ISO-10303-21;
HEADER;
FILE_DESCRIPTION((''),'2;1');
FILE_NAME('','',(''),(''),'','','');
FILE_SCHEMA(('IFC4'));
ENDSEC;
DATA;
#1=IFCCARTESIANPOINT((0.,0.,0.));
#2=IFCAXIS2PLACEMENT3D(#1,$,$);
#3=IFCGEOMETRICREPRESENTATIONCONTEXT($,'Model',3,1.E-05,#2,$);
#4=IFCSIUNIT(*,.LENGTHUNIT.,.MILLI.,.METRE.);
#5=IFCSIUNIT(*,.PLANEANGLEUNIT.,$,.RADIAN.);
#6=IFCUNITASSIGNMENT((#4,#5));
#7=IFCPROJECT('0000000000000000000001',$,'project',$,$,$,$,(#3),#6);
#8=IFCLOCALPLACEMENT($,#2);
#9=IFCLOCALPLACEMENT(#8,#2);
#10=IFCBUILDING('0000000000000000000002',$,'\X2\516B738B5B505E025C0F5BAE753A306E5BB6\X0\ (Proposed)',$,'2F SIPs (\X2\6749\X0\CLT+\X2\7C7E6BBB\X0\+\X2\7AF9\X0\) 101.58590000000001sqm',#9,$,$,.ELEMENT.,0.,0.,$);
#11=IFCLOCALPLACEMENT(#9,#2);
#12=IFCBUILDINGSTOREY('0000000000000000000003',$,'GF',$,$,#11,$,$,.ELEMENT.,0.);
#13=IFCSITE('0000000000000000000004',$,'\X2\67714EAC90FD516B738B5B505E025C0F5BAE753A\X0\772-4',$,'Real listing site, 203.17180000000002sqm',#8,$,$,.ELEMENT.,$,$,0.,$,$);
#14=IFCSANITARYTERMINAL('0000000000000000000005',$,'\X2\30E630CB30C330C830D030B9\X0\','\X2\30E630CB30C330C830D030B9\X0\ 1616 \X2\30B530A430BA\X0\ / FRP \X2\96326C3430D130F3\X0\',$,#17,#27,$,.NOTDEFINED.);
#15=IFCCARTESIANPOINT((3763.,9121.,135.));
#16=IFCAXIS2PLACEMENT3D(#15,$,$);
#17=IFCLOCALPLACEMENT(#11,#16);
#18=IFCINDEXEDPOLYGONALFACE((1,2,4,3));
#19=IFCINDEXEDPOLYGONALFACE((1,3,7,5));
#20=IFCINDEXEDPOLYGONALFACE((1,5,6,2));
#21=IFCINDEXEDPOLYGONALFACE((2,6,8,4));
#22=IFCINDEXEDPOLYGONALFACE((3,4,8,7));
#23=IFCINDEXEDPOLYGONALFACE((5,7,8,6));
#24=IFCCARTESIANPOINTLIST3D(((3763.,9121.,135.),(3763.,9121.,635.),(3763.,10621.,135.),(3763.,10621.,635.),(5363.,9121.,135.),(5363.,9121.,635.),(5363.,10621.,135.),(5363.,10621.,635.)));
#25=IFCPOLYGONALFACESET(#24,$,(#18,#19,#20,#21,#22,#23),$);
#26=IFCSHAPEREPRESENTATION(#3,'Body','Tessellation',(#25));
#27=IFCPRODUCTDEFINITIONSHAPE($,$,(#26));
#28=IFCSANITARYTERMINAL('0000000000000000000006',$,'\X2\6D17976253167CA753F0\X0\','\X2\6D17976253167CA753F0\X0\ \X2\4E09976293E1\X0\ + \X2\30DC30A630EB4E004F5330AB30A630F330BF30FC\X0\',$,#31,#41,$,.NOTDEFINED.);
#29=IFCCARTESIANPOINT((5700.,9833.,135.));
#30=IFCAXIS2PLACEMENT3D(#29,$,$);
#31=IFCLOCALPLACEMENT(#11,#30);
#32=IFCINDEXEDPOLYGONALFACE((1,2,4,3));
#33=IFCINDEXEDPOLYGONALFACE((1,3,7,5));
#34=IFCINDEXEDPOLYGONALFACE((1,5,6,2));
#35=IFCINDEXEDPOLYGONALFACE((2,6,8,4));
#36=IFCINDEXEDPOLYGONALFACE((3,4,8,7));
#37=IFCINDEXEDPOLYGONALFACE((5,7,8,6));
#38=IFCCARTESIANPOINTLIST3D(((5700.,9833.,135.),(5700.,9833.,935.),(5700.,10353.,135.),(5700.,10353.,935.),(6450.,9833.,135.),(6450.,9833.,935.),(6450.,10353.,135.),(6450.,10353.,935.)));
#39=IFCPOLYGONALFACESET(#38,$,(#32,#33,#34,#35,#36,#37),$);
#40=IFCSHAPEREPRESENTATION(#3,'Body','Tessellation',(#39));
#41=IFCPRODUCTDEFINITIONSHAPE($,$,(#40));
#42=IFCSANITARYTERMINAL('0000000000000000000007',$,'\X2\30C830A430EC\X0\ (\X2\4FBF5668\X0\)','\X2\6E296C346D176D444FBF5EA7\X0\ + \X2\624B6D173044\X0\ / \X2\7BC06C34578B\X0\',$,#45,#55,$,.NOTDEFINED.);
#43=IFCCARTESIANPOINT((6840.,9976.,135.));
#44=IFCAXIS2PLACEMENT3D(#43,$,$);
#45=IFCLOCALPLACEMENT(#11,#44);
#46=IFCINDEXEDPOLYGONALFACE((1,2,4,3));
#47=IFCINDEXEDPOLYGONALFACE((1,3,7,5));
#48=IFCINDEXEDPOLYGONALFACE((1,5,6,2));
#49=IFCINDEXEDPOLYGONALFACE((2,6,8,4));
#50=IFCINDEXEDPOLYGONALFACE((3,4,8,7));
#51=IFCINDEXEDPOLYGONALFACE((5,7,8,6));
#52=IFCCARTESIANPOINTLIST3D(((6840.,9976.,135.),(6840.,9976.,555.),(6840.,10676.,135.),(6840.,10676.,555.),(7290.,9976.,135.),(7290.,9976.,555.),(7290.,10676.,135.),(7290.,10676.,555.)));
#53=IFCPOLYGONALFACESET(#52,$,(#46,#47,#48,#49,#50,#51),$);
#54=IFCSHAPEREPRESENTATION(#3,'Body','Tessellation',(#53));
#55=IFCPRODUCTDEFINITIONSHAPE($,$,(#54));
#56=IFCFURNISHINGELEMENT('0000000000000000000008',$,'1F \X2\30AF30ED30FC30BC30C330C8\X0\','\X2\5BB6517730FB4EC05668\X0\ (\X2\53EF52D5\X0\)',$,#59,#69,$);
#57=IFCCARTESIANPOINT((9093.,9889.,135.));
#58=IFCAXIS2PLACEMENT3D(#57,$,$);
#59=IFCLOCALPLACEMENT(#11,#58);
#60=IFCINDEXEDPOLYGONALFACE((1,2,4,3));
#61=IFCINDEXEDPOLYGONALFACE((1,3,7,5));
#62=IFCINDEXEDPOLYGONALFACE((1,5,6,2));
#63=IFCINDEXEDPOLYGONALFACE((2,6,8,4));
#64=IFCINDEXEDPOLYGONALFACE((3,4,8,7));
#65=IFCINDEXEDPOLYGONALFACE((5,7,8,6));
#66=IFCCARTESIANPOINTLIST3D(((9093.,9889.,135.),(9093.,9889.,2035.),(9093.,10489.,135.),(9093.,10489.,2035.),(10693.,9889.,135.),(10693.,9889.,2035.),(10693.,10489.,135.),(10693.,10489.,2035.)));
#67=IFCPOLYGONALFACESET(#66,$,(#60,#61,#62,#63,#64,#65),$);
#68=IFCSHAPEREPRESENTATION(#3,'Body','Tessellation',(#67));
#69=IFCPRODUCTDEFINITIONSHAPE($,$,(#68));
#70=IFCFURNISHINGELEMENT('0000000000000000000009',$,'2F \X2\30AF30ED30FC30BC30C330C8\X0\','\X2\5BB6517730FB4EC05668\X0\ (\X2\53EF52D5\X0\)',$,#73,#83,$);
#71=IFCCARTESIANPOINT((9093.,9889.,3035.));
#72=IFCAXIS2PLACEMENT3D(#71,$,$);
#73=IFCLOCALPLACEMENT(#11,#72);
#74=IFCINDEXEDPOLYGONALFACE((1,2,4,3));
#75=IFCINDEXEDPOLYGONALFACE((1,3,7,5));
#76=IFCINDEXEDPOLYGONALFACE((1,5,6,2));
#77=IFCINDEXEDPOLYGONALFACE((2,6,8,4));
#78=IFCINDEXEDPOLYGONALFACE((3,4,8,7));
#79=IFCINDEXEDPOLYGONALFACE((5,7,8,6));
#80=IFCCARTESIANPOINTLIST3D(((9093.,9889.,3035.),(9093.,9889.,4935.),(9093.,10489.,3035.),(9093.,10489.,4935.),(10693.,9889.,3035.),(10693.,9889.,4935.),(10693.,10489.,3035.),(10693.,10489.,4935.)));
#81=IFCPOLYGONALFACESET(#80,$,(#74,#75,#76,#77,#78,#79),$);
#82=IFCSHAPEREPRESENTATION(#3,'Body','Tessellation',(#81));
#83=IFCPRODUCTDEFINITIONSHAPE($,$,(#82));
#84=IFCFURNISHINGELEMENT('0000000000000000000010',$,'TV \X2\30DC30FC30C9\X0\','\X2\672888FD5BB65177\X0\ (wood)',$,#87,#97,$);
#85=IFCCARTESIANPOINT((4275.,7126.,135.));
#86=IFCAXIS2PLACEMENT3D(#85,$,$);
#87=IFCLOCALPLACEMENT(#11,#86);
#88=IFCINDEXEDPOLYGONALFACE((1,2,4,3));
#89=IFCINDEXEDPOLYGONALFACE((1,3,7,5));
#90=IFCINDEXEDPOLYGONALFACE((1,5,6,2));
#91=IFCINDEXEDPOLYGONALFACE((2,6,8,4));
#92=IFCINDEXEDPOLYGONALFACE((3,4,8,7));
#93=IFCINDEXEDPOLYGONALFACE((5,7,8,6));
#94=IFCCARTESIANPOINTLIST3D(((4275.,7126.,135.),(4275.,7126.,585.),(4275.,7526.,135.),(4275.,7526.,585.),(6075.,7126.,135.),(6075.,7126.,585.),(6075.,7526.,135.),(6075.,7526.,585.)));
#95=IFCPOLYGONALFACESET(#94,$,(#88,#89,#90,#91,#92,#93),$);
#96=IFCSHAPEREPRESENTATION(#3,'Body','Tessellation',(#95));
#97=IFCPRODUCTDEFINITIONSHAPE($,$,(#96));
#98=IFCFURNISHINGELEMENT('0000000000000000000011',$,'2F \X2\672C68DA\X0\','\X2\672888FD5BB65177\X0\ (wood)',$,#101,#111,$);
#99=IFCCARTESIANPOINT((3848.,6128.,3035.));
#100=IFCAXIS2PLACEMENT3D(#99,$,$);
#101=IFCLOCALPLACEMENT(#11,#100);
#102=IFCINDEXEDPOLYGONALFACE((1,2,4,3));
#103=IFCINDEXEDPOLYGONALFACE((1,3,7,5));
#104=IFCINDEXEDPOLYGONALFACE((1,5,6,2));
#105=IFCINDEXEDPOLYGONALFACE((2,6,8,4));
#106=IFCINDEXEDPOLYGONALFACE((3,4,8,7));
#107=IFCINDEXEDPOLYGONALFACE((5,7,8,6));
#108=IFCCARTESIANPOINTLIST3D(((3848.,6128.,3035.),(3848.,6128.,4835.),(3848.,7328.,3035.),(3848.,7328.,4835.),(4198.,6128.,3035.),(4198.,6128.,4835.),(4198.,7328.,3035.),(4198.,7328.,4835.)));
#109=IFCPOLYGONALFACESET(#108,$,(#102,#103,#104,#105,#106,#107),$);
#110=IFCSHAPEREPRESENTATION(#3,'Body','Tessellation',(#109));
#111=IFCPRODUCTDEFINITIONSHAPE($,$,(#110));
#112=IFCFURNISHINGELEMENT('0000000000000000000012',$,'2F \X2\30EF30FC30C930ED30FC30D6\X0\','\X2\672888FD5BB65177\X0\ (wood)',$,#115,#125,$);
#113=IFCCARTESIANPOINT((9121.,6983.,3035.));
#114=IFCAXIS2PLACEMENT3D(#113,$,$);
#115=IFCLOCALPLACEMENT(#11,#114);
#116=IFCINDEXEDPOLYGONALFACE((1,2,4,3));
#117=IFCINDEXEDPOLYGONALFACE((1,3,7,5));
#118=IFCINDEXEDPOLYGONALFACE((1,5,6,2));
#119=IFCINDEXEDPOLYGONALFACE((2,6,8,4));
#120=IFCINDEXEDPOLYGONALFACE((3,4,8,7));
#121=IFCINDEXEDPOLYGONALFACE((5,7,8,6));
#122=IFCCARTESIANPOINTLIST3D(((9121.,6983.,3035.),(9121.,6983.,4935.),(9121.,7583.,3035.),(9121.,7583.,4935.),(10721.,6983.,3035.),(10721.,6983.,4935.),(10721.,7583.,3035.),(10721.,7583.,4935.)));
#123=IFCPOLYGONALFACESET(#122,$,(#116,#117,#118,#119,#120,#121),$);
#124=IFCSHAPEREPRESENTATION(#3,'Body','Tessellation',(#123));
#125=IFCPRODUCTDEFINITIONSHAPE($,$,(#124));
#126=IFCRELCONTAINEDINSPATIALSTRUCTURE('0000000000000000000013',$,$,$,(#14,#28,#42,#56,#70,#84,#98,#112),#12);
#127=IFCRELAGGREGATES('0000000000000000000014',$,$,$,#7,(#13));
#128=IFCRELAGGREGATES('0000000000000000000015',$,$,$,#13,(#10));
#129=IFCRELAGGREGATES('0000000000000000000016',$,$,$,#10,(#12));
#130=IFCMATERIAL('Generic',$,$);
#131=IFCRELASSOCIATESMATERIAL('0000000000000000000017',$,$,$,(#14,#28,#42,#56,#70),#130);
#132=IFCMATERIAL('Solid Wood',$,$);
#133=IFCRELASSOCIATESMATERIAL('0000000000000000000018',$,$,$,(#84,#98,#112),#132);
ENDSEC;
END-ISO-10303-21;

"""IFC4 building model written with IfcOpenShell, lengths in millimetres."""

from ifc_helpers import new_model, si_unit, frame, frame_2d, origin, place, context, project, spatial, rectangle, extrude, material, element, save


model = new_model("IFC4")

# Units and contexts
model_context = context("Model", 3, precision=1e-05, world=origin())
ifc_project = project(units=[si_unit("LENGTHUNIT", "METRE", prefix="MILLI"), si_unit("PLANEANGLEUNIT", "RADIAN")], contexts=[model_context])

# Site, building, storey
site_placement = place(None, origin())
site = spatial("IfcSite", under=ifc_project, at=site_placement, Name="東京都八王子市小宮町772-4", ObjectType="Real listing site, 203.17180000000002sqm", CompositionType="ELEMENT", RefElevation=0.0)
building_placement = place(site_placement, origin())
building = spatial("IfcBuilding", under=site, at=building_placement, Name="八王子市小宮町の家 (Proposed)", ObjectType="2F SIPs (杉CLT+籾殻+竹) 101.58590000000001sqm", CompositionType="ELEMENT", ElevationOfRefHeight=0.0, ElevationOfTerrain=0.0)
storey_placement = place(building_placement, origin())
storey = spatial("IfcBuildingStorey", under=building, at=storey_placement, Name="GF", CompositionType="ELEMENT", Elevation=0.0)

# Shared definitions
ifc_material_1 = material(Name="Solid Wood")

# Sanitary terminals
ifc_material_2 = material(Name="Generic")
sanitary_terminal_1_placement = place(storey_placement, frame((3763.0, 9121.0, 135.0)))
element("IfcSanitaryTerminal", 1, at=sanitary_terminal_1_placement, inside=storey, material=ifc_material_2, Name="ユニットバス", Description="ユニットバス 1616 サイズ / FRP 防水パン", PredefinedType="NOTDEFINED", context=model_context, shape_type="SweptSolid", body=[
    extrude(rectangle(XDim=1600.0, YDim=1500.0, at=frame_2d((800.0, 750.0))), frame((3763.0, 9121.0, 135.0)), (0.0, 0.0, 1.0), 500.0),
])
sanitary_terminal_2_placement = place(storey_placement, frame((5700.0, 9833.0, 135.0)))
element("IfcSanitaryTerminal", 2, at=sanitary_terminal_2_placement, inside=storey, material=ifc_material_2, Name="洗面化粧台", Description="洗面化粧台 三面鏡 + ボウル一体カウンター", PredefinedType="NOTDEFINED", context=model_context, shape_type="SweptSolid", body=[
    extrude(rectangle(XDim=750.0, YDim=520.0, at=frame_2d((375.0, 260.0))), frame((5700.0, 9833.0, 135.0)), (0.0, 0.0, 1.0), 800.0),
])
sanitary_terminal_3_placement = place(storey_placement, frame((6840.0, 9976.0, 135.0)))
element("IfcSanitaryTerminal", 3, at=sanitary_terminal_3_placement, inside=storey, material=ifc_material_2, Name="トイレ (便器)", Description="温水洗浄便座 + 手洗い / 節水型", PredefinedType="NOTDEFINED", context=model_context, shape_type="SweptSolid", body=[
    extrude(rectangle(XDim=450.0, YDim=700.0, at=frame_2d((225.0, 350.0))), frame((6840.0, 9976.0, 135.0)), (0.0, 0.0, 1.0), 420.0),
])

# Furnishing elements
furnishing_1_placement = place(storey_placement, frame((9093.0, 9889.0, 135.0)))
element("IfcFurnishingElement", 4, at=furnishing_1_placement, inside=storey, material=ifc_material_2, Name="1F クローゼット", Description="家具・什器 (可動)", context=model_context, shape_type="SweptSolid", body=[
    extrude(rectangle(XDim=1600.0, YDim=600.0, at=frame_2d((800.0, 300.0))), frame((9093.0, 9889.0, 135.0)), (0.0, 0.0, 1.0), 1900.0),
])
furnishing_2_placement = place(storey_placement, frame((9093.0, 9889.0, 3035.0)))
element("IfcFurnishingElement", 5, at=furnishing_2_placement, inside=storey, material=ifc_material_2, Name="2F クローゼット", Description="家具・什器 (可動)", context=model_context, shape_type="SweptSolid", body=[
    extrude(rectangle(XDim=1600.0, YDim=600.0, at=frame_2d((800.0, 300.0))), frame((9093.0, 9889.0, 3035.0)), (0.0, 0.0, 1.0), 1900.0),
])
furnishing_3_placement = place(storey_placement, frame((4275.0, 7126.0, 135.0)))
element("IfcFurnishingElement", 6, at=furnishing_3_placement, inside=storey, material=ifc_material_1, Name="TV ボード", Description="木製家具 (wood)", context=model_context, shape_type="SweptSolid", body=[
    extrude(rectangle(XDim=1800.0, YDim=400.0, at=frame_2d((900.0, 200.0))), frame((4275.0, 7126.0, 135.0)), (0.0, 0.0, 1.0), 450.0),
])
furnishing_4_placement = place(storey_placement, frame((3848.0, 6128.0, 3035.0)))
element("IfcFurnishingElement", 7, at=furnishing_4_placement, inside=storey, material=ifc_material_1, Name="2F 本棚", Description="木製家具 (wood)", context=model_context, shape_type="SweptSolid", body=[
    extrude(rectangle(XDim=350.0, YDim=1200.0, at=frame_2d((175.0, 600.0))), frame((3848.0, 6128.0, 3035.0)), (0.0, 0.0, 1.0), 1800.0),
])
furnishing_5_placement = place(storey_placement, frame((9121.0, 6983.0, 3035.0)))
element("IfcFurnishingElement", 8, at=furnishing_5_placement, inside=storey, material=ifc_material_1, Name="2F ワードローブ", Description="木製家具 (wood)", context=model_context, shape_type="SweptSolid", body=[
    extrude(rectangle(XDim=1600.0, YDim=600.0, at=frame_2d((800.0, 300.0))), frame((9121.0, 6983.0, 3035.0)), (0.0, 0.0, 1.0), 1900.0),
])

save(model, "model.ifc")
